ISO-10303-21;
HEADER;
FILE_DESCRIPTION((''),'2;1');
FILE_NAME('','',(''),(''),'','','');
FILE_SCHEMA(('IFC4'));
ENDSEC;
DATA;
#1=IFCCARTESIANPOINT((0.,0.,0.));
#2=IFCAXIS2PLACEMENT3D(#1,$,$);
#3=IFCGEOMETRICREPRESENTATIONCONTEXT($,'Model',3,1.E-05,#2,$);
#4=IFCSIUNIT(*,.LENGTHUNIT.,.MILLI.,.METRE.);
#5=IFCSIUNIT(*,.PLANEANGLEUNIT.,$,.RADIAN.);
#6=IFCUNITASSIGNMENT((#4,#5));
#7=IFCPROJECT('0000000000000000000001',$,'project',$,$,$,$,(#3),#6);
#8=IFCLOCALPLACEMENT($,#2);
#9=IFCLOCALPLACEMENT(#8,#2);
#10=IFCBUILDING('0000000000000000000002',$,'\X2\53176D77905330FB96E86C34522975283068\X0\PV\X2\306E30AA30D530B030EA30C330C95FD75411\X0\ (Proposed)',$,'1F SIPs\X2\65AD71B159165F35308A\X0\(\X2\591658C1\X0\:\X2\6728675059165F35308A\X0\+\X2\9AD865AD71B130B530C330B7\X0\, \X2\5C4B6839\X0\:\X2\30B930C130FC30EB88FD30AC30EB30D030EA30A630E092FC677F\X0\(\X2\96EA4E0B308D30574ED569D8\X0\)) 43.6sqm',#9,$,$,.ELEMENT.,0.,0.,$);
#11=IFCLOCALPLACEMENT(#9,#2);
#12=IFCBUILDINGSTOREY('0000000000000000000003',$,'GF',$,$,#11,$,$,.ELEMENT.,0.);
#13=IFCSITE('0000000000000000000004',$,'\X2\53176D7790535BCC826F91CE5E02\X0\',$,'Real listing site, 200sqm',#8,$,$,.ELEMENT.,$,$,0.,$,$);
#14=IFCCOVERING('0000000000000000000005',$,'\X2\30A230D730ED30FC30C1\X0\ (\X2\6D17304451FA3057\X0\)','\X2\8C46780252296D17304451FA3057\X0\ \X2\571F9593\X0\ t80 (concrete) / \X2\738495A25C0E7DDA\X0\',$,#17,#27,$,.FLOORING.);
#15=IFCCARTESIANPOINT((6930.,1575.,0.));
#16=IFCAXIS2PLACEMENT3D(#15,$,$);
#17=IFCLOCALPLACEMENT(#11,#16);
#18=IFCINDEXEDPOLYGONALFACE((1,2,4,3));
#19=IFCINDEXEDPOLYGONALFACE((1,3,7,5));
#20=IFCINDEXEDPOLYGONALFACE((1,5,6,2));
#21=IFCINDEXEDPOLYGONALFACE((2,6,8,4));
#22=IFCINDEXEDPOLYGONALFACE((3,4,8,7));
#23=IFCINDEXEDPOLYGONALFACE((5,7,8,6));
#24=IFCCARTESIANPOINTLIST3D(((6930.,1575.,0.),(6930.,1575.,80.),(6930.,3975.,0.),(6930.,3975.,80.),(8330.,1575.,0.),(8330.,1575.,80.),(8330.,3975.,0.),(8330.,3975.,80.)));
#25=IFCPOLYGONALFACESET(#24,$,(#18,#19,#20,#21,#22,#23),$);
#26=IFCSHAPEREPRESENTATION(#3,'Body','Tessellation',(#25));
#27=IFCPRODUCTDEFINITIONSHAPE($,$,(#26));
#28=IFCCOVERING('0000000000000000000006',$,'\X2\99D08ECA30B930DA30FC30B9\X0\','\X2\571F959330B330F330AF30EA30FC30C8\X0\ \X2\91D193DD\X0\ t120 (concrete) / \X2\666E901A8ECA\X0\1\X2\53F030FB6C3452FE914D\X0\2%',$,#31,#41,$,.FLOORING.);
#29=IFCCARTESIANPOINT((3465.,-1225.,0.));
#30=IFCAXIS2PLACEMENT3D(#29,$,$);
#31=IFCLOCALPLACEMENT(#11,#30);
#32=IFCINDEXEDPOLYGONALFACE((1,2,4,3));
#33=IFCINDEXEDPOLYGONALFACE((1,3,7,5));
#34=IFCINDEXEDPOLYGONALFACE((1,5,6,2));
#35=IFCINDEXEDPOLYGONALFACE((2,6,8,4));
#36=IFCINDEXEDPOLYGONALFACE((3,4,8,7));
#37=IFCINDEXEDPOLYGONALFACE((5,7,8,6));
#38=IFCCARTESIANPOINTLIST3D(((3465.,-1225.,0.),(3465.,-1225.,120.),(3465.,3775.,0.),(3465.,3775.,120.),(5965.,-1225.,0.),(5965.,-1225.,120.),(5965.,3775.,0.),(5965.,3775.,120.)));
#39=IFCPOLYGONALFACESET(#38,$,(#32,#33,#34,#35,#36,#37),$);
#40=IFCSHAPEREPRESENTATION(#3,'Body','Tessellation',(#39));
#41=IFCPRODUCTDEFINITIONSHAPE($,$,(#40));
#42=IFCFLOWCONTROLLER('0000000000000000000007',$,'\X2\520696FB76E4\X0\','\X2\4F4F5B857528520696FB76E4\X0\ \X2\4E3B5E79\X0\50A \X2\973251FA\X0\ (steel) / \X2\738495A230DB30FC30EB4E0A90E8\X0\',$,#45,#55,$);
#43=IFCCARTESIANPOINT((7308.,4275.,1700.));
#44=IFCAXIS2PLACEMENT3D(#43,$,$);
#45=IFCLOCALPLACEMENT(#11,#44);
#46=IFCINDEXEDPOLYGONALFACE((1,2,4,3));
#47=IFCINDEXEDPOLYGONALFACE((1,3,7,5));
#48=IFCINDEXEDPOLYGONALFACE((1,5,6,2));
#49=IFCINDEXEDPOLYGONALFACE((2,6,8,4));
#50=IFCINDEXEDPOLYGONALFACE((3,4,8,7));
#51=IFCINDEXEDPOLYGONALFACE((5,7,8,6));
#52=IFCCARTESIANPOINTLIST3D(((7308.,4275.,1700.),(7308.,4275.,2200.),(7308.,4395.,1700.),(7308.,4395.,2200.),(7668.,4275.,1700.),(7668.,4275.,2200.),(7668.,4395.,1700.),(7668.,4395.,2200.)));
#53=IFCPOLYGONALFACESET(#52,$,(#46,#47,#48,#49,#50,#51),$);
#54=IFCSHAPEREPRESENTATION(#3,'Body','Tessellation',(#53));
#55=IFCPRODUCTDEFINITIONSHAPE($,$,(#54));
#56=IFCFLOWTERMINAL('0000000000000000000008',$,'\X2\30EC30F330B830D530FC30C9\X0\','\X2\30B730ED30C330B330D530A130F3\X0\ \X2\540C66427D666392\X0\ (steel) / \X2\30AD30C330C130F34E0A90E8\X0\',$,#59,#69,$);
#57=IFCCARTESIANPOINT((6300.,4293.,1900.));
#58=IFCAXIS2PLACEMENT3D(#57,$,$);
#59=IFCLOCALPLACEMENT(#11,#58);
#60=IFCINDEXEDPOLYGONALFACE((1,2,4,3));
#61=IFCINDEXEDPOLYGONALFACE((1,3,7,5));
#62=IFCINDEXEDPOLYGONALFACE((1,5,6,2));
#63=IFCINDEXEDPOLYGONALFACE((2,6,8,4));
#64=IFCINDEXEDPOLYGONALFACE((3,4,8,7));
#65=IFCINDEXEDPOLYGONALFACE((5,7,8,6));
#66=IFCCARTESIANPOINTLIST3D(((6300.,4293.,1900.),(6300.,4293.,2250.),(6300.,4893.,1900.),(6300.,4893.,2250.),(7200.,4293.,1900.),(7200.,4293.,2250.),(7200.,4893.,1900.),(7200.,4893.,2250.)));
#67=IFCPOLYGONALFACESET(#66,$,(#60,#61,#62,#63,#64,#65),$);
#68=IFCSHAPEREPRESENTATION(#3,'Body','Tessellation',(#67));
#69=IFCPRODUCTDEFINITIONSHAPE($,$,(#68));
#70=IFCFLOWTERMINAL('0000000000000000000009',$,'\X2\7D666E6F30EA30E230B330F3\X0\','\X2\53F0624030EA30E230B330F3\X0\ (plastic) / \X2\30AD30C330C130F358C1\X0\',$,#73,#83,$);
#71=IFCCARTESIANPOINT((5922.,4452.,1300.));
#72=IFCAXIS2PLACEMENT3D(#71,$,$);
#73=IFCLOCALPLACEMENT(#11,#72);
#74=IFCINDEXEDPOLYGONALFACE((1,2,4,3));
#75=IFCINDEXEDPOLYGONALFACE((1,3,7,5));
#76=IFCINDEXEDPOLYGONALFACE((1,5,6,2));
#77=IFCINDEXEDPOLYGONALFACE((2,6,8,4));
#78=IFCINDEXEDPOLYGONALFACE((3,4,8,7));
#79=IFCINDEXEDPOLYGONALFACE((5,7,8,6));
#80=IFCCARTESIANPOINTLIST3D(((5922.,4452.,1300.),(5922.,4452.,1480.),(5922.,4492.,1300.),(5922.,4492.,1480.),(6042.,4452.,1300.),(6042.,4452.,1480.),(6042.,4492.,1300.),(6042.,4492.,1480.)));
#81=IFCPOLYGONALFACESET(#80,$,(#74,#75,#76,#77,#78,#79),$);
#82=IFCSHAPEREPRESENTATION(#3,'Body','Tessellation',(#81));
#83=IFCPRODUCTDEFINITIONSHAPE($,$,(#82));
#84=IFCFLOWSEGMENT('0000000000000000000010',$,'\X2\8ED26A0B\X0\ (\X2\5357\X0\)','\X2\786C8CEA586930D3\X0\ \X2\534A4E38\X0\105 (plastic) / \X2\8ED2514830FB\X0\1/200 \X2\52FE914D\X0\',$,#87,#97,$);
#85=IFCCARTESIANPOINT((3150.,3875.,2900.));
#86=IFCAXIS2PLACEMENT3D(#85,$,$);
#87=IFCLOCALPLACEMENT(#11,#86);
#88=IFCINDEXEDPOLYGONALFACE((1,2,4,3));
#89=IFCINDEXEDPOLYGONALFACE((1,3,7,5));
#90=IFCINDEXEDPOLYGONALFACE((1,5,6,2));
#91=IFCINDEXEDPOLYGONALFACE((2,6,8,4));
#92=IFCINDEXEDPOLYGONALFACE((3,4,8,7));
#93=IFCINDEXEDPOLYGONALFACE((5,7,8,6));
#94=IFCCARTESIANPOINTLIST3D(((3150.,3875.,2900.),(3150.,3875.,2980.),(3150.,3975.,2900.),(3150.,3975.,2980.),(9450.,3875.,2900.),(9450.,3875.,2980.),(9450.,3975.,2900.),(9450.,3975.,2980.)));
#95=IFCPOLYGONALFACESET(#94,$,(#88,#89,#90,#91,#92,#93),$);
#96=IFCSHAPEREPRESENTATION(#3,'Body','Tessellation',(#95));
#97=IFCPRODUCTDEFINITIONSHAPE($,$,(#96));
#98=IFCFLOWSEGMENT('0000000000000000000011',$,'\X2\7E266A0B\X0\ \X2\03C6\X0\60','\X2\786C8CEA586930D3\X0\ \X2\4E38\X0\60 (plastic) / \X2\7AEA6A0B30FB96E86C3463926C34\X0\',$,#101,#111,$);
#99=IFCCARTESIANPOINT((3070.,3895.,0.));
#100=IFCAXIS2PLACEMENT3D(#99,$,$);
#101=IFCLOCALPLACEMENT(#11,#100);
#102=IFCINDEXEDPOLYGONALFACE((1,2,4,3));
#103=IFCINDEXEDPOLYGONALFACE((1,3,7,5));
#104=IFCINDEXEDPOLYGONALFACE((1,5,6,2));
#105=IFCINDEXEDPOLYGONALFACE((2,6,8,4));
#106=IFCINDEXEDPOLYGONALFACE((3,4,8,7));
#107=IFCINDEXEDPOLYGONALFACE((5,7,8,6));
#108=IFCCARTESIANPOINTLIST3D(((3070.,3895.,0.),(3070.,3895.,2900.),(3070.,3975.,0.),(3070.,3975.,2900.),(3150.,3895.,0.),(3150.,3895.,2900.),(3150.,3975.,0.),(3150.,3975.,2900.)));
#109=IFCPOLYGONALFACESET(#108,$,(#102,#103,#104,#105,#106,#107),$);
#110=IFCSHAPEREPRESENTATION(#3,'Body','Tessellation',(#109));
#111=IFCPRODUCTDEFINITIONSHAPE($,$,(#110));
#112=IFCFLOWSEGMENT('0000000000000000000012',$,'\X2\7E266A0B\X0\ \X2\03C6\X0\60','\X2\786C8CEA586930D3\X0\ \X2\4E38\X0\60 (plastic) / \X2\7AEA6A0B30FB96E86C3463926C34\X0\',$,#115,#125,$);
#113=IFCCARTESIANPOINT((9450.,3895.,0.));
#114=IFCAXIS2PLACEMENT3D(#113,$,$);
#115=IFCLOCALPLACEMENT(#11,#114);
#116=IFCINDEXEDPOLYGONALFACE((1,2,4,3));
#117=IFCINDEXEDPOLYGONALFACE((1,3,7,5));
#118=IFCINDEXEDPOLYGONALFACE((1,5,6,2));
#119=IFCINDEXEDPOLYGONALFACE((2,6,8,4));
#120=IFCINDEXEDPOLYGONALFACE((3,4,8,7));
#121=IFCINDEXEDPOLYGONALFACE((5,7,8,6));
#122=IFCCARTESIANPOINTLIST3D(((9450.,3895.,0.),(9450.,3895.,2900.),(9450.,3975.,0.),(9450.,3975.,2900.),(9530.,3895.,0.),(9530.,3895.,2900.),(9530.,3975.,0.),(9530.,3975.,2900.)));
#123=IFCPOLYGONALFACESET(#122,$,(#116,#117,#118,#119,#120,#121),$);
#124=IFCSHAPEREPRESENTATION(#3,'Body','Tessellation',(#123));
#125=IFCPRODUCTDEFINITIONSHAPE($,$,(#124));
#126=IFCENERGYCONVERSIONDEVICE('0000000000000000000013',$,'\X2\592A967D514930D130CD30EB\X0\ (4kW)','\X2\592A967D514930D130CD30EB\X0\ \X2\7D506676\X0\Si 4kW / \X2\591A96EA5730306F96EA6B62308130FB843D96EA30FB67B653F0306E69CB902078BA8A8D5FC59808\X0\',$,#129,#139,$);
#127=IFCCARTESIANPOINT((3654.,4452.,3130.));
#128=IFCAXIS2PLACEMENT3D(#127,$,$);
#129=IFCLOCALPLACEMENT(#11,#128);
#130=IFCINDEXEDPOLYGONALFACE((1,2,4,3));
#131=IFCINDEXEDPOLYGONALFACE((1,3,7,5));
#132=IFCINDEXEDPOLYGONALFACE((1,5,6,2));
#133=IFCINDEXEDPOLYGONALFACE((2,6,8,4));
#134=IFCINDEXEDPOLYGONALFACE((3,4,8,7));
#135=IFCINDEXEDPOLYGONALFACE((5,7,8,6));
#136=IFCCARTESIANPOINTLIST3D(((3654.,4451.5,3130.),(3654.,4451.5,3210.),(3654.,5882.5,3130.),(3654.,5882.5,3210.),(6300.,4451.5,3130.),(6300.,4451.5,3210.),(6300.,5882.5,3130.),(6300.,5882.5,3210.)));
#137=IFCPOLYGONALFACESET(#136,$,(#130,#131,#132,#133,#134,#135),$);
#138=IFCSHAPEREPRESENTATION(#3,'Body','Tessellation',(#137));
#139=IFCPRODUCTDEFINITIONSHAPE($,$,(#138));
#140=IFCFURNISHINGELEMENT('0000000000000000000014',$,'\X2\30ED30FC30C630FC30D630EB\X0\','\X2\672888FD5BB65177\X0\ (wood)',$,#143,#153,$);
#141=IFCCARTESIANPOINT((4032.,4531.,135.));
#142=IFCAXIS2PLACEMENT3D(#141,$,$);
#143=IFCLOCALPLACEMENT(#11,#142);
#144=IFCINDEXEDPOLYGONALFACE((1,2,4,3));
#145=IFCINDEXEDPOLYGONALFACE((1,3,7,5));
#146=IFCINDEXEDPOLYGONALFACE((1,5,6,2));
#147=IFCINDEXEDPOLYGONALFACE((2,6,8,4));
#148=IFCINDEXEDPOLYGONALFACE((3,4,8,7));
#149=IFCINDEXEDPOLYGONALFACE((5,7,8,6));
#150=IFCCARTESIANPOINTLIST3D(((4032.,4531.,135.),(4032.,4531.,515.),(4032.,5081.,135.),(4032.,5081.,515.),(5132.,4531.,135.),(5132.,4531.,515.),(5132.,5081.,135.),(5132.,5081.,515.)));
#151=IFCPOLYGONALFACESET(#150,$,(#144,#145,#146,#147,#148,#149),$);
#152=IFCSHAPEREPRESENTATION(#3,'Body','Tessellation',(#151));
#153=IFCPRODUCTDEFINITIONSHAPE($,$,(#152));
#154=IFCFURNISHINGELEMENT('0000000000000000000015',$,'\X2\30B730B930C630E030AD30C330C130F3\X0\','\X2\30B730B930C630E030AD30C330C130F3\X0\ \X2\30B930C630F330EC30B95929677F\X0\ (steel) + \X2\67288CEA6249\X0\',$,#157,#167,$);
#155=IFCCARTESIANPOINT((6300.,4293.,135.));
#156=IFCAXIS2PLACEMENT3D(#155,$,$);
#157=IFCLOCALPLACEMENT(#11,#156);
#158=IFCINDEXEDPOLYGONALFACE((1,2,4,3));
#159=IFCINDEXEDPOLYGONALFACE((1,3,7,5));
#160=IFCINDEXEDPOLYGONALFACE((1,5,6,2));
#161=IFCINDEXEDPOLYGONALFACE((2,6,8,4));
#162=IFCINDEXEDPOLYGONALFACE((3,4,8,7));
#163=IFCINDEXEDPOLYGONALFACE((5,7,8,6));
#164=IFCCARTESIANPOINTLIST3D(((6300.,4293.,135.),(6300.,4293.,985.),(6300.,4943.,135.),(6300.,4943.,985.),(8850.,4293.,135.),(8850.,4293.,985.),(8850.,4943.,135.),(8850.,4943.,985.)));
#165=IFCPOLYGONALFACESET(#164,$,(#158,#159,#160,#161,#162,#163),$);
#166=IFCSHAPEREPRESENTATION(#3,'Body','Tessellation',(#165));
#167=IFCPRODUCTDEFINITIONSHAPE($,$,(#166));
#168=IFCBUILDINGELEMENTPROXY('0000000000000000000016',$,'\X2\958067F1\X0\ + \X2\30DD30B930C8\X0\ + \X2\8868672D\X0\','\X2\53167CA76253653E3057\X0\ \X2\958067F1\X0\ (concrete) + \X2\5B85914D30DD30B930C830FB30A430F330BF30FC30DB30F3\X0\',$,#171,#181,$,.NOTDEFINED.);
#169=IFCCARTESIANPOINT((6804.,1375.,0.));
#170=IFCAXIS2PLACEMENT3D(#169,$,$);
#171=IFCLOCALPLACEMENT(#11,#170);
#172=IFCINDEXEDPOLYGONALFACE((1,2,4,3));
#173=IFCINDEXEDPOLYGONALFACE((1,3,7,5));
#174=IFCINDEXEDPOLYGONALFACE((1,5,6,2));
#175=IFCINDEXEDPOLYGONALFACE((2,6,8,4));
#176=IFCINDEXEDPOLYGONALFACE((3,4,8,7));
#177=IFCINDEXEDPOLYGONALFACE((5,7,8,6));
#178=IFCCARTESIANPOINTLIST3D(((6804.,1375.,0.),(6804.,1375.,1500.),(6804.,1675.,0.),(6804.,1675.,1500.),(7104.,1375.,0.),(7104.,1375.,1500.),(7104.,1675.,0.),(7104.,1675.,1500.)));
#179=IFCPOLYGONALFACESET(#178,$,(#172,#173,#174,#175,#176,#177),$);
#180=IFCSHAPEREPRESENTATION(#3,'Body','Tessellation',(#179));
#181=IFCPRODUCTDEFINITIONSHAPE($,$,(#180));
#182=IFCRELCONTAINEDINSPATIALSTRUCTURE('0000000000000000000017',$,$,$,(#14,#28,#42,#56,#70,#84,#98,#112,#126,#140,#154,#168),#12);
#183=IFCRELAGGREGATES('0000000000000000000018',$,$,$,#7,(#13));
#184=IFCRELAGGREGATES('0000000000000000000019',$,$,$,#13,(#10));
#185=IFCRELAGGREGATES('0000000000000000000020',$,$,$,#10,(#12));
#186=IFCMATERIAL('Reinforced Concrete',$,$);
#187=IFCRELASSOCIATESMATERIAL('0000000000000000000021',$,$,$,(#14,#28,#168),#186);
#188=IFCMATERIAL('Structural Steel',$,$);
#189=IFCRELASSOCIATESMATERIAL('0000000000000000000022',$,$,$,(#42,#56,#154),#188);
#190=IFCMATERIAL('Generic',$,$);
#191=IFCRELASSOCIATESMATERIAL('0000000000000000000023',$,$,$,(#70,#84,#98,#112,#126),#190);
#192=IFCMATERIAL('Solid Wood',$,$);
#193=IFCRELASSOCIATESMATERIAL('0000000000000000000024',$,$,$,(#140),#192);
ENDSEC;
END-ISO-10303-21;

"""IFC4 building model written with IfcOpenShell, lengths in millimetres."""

from ifc_helpers import new_model, si_unit, frame, frame_2d, origin, place, context, project, spatial, rectangle, extrude, material, element, save


model = new_model("IFC4")

# Units and contexts
model_context = context("Model", 3, precision=1e-05, world=origin())
ifc_project = project(units=[si_unit("LENGTHUNIT", "METRE", prefix="MILLI"), si_unit("PLANEANGLEUNIT", "RADIAN")], contexts=[model_context])

# Site, building, storey
site_placement = place(None, origin())
site = spatial("IfcSite", under=ifc_project, at=site_placement, Name="北海道富良野市", ObjectType="Real listing site, 200sqm", CompositionType="ELEMENT", RefElevation=0.0)
building_placement = place(site_placement, origin())
building = spatial("IfcBuilding", under=site, at=building_placement, Name="北海道・雨水利用とPVのオフグリッド志向 (Proposed)", ObjectType="1F SIPs断熱外張り(外壁:木材外張り+高断熱サッシ, 屋根:スチール製ガルバリウム鋼板(雪下ろし仕様)) 43.6sqm", CompositionType="ELEMENT", ElevationOfRefHeight=0.0, ElevationOfTerrain=0.0)
storey_placement = place(building_placement, origin())
storey = spatial("IfcBuildingStorey", under=building, at=storey_placement, Name="GF", CompositionType="ELEMENT", Elevation=0.0)

# Shared definitions
ifc_material_1 = material(Name="Solid Wood")

# Shared definitions
ifc_material_2 = material(Name="Reinforced Concrete")

# Shared definitions
ifc_material_3 = material(Name="Structural Steel")

# Coverings
ifc_material_4 = material(Name="Generic")
covering_1_placement = place(storey_placement, frame((6930.0, 1575.0, 0.0)))
element("IfcCovering", 1, at=covering_1_placement, inside=storey, material=ifc_material_2, Name="アプローチ (洗い出し)", Description="豆砂利洗い出し 土間 t80 (concrete) / 玄関導線", PredefinedType="FLOORING", context=model_context, shape_type="SweptSolid", body=[
    extrude(rectangle(XDim=1400.0, YDim=2400.0, at=frame_2d((700.0, 1200.0))), frame((6930.0, 1575.0, 0.0)), (0.0, 0.0, 1.0), 80.0),
])
covering_2_placement = place(storey_placement, frame((3465.0, -1225.0, 0.0)))
element("IfcCovering", 2, at=covering_2_placement, inside=storey, material=ifc_material_2, Name="駐車スペース", Description="土間コンクリート 金鏝 t120 (concrete) / 普通車1台・水勾配2%", PredefinedType="FLOORING", context=model_context, shape_type="SweptSolid", body=[
    extrude(rectangle(XDim=2500.0, YDim=5000.0, at=frame_2d((1250.0, 2500.0))), frame((3465.0, -1225.0, 0.0)), (0.0, 0.0, 1.0), 120.0),
])

# Flow controller
flow_controller_placement = place(storey_placement, frame((7308.0, 4275.0, 1700.0)))
element("IfcFlowController", 3, at=flow_controller_placement, inside=storey, material=ifc_material_3, Name="分電盤", Description="住宅用分電盤 主幹50A 露出 (steel) / 玄関ホール上部", context=model_context, shape_type="SweptSolid", body=[
    extrude(rectangle(XDim=360.0, YDim=120.0, at=frame_2d((180.0, 60.0))), frame((7308.0, 4275.0, 1700.0)), (0.0, 0.0, 1.0), 500.0),
])

# Flow terminals
flow_terminal_1_placement = place(storey_placement, frame((6300.0, 4293.0, 1900.0)))
element("IfcFlowTerminal", 4, at=flow_terminal_1_placement, inside=storey, material=ifc_material_3, Name="レンジフード", Description="シロッコファン 同時給排 (steel) / キッチン上部", context=model_context, shape_type="SweptSolid", body=[
    extrude(rectangle(XDim=900.0, YDim=600.0, at=frame_2d((450.0, 300.0))), frame((6300.0, 4293.0, 1900.0)), (0.0, 0.0, 1.0), 350.0),
])
flow_terminal_2_placement = place(storey_placement, frame((5922.0, 4452.0, 1300.0)))
element("IfcFlowTerminal", 5, at=flow_terminal_2_placement, inside=storey, material=ifc_material_4, Name="給湯リモコン", Description="台所リモコン (plastic) / キッチン壁", context=model_context, shape_type="SweptSolid", body=[
    extrude(rectangle(XDim=120.0, YDim=40.0, at=frame_2d((60.0, 20.0))), frame((5922.0, 4452.0, 1300.0)), (0.0, 0.0, 1.0), 180.0),
])

# Flow segments
flow_segment_1_placement = place(storey_placement, frame((3150.0, 3875.0, 2900.0)))
element("IfcFlowSegment", 6, at=flow_segment_1_placement, inside=storey, material=ifc_material_4, Name="軒樋 (南)", Description="硬質塩ビ 半丸105 (plastic) / 軒先・1/200 勾配", context=model_context, shape_type="SweptSolid", body=[
    extrude(rectangle(XDim=6300.0, YDim=100.0, at=frame_2d((3150.0, 50.0))), frame((3150.0, 3875.0, 2900.0)), (0.0, 0.0, 1.0), 80.0),
])
flow_segment_2_placement = place(storey_placement, frame((3070.0, 3895.0, 0.0)))
element("IfcFlowSegment", 7, at=flow_segment_2_placement, inside=storey, material=ifc_material_4, Name="縦樋 φ60", Description="硬質塩ビ 丸60 (plastic) / 竪樋・雨水排水", context=model_context, shape_type="SweptSolid", body=[
    extrude(rectangle(XDim=80.0, YDim=80.0, at=frame_2d((40.0, 40.0))), frame((3070.0, 3895.0, 0.0)), (0.0, 0.0, 1.0), 2900.0),
])
flow_segment_3_placement = place(storey_placement, frame((9450.0, 3895.0, 0.0)))
element("IfcFlowSegment", 8, at=flow_segment_3_placement, inside=storey, material=ifc_material_4, Name="縦樋 φ60", Description="硬質塩ビ 丸60 (plastic) / 竪樋・雨水排水", context=model_context, shape_type="SweptSolid", body=[
    extrude(rectangle(XDim=80.0, YDim=80.0, at=frame_2d((40.0, 40.0))), frame((9450.0, 3895.0, 0.0)), (0.0, 0.0, 1.0), 2900.0),
])

# Energy conversion device
energy_conversion_device_placement = place(storey_placement, frame((3654.0, 4452.0, 3130.0)))
element("IfcEnergyConversionDevice", 9, at=energy_conversion_device_placement, inside=storey, material=ifc_material_4, Name="太陽光パネル (4kW)", Description="太陽光パネル 結晶Si 4kW / 多雪地は雪止め・落雪・架台の構造確認必須", context=model_context, shape_type="SweptSolid", body=[
    extrude(rectangle(XDim=2646.0, YDim=1431.0, at=frame_2d((1323.0, 715.0))), frame((3654.0, 4452.0, 3130.0)), (0.0, 0.0, 1.0), 80.0),
])

# Furnishing elements
furnishing_1_placement = place(storey_placement, frame((4032.0, 4531.0, 135.0)))
element("IfcFurnishingElement", 10, at=furnishing_1_placement, inside=storey, material=ifc_material_1, Name="ローテーブル", Description="木製家具 (wood)", context=model_context, shape_type="SweptSolid", body=[
    extrude(rectangle(XDim=1100.0, YDim=550.0, at=frame_2d((550.0, 275.0))), frame((4032.0, 4531.0, 135.0)), (0.0, 0.0, 1.0), 380.0),
])
furnishing_2_placement = place(storey_placement, frame((6300.0, 4293.0, 135.0)))
element("IfcFurnishingElement", 11, at=furnishing_2_placement, inside=storey, material=ifc_material_3, Name="システムキッチン", Description="システムキッチン ステンレス天板 (steel) + 木質扉", context=model_context, shape_type="SweptSolid", body=[
    extrude(rectangle(XDim=2550.0, YDim=650.0, at=frame_2d((1275.0, 325.0))), frame((6300.0, 4293.0, 135.0)), (0.0, 0.0, 1.0), 850.0),
])

# Building element proxy
proxy_placement = place(storey_placement, frame((6804.0, 1375.0, 0.0)))
element("IfcBuildingElementProxy", 12, at=proxy_placement, inside=storey, material=ifc_material_2, Name="門柱 + ポスト + 表札", Description="化粧打放し 門柱 (concrete) + 宅配ポスト・インターホン", PredefinedType="NOTDEFINED", context=model_context, shape_type="SweptSolid", body=[
    extrude(rectangle(XDim=300.0, YDim=300.0, at=frame_2d((150.0, 150.0))), frame((6804.0, 1375.0, 0.0)), (0.0, 0.0, 1.0), 1500.0),
])

save(model, "model.ifc")
